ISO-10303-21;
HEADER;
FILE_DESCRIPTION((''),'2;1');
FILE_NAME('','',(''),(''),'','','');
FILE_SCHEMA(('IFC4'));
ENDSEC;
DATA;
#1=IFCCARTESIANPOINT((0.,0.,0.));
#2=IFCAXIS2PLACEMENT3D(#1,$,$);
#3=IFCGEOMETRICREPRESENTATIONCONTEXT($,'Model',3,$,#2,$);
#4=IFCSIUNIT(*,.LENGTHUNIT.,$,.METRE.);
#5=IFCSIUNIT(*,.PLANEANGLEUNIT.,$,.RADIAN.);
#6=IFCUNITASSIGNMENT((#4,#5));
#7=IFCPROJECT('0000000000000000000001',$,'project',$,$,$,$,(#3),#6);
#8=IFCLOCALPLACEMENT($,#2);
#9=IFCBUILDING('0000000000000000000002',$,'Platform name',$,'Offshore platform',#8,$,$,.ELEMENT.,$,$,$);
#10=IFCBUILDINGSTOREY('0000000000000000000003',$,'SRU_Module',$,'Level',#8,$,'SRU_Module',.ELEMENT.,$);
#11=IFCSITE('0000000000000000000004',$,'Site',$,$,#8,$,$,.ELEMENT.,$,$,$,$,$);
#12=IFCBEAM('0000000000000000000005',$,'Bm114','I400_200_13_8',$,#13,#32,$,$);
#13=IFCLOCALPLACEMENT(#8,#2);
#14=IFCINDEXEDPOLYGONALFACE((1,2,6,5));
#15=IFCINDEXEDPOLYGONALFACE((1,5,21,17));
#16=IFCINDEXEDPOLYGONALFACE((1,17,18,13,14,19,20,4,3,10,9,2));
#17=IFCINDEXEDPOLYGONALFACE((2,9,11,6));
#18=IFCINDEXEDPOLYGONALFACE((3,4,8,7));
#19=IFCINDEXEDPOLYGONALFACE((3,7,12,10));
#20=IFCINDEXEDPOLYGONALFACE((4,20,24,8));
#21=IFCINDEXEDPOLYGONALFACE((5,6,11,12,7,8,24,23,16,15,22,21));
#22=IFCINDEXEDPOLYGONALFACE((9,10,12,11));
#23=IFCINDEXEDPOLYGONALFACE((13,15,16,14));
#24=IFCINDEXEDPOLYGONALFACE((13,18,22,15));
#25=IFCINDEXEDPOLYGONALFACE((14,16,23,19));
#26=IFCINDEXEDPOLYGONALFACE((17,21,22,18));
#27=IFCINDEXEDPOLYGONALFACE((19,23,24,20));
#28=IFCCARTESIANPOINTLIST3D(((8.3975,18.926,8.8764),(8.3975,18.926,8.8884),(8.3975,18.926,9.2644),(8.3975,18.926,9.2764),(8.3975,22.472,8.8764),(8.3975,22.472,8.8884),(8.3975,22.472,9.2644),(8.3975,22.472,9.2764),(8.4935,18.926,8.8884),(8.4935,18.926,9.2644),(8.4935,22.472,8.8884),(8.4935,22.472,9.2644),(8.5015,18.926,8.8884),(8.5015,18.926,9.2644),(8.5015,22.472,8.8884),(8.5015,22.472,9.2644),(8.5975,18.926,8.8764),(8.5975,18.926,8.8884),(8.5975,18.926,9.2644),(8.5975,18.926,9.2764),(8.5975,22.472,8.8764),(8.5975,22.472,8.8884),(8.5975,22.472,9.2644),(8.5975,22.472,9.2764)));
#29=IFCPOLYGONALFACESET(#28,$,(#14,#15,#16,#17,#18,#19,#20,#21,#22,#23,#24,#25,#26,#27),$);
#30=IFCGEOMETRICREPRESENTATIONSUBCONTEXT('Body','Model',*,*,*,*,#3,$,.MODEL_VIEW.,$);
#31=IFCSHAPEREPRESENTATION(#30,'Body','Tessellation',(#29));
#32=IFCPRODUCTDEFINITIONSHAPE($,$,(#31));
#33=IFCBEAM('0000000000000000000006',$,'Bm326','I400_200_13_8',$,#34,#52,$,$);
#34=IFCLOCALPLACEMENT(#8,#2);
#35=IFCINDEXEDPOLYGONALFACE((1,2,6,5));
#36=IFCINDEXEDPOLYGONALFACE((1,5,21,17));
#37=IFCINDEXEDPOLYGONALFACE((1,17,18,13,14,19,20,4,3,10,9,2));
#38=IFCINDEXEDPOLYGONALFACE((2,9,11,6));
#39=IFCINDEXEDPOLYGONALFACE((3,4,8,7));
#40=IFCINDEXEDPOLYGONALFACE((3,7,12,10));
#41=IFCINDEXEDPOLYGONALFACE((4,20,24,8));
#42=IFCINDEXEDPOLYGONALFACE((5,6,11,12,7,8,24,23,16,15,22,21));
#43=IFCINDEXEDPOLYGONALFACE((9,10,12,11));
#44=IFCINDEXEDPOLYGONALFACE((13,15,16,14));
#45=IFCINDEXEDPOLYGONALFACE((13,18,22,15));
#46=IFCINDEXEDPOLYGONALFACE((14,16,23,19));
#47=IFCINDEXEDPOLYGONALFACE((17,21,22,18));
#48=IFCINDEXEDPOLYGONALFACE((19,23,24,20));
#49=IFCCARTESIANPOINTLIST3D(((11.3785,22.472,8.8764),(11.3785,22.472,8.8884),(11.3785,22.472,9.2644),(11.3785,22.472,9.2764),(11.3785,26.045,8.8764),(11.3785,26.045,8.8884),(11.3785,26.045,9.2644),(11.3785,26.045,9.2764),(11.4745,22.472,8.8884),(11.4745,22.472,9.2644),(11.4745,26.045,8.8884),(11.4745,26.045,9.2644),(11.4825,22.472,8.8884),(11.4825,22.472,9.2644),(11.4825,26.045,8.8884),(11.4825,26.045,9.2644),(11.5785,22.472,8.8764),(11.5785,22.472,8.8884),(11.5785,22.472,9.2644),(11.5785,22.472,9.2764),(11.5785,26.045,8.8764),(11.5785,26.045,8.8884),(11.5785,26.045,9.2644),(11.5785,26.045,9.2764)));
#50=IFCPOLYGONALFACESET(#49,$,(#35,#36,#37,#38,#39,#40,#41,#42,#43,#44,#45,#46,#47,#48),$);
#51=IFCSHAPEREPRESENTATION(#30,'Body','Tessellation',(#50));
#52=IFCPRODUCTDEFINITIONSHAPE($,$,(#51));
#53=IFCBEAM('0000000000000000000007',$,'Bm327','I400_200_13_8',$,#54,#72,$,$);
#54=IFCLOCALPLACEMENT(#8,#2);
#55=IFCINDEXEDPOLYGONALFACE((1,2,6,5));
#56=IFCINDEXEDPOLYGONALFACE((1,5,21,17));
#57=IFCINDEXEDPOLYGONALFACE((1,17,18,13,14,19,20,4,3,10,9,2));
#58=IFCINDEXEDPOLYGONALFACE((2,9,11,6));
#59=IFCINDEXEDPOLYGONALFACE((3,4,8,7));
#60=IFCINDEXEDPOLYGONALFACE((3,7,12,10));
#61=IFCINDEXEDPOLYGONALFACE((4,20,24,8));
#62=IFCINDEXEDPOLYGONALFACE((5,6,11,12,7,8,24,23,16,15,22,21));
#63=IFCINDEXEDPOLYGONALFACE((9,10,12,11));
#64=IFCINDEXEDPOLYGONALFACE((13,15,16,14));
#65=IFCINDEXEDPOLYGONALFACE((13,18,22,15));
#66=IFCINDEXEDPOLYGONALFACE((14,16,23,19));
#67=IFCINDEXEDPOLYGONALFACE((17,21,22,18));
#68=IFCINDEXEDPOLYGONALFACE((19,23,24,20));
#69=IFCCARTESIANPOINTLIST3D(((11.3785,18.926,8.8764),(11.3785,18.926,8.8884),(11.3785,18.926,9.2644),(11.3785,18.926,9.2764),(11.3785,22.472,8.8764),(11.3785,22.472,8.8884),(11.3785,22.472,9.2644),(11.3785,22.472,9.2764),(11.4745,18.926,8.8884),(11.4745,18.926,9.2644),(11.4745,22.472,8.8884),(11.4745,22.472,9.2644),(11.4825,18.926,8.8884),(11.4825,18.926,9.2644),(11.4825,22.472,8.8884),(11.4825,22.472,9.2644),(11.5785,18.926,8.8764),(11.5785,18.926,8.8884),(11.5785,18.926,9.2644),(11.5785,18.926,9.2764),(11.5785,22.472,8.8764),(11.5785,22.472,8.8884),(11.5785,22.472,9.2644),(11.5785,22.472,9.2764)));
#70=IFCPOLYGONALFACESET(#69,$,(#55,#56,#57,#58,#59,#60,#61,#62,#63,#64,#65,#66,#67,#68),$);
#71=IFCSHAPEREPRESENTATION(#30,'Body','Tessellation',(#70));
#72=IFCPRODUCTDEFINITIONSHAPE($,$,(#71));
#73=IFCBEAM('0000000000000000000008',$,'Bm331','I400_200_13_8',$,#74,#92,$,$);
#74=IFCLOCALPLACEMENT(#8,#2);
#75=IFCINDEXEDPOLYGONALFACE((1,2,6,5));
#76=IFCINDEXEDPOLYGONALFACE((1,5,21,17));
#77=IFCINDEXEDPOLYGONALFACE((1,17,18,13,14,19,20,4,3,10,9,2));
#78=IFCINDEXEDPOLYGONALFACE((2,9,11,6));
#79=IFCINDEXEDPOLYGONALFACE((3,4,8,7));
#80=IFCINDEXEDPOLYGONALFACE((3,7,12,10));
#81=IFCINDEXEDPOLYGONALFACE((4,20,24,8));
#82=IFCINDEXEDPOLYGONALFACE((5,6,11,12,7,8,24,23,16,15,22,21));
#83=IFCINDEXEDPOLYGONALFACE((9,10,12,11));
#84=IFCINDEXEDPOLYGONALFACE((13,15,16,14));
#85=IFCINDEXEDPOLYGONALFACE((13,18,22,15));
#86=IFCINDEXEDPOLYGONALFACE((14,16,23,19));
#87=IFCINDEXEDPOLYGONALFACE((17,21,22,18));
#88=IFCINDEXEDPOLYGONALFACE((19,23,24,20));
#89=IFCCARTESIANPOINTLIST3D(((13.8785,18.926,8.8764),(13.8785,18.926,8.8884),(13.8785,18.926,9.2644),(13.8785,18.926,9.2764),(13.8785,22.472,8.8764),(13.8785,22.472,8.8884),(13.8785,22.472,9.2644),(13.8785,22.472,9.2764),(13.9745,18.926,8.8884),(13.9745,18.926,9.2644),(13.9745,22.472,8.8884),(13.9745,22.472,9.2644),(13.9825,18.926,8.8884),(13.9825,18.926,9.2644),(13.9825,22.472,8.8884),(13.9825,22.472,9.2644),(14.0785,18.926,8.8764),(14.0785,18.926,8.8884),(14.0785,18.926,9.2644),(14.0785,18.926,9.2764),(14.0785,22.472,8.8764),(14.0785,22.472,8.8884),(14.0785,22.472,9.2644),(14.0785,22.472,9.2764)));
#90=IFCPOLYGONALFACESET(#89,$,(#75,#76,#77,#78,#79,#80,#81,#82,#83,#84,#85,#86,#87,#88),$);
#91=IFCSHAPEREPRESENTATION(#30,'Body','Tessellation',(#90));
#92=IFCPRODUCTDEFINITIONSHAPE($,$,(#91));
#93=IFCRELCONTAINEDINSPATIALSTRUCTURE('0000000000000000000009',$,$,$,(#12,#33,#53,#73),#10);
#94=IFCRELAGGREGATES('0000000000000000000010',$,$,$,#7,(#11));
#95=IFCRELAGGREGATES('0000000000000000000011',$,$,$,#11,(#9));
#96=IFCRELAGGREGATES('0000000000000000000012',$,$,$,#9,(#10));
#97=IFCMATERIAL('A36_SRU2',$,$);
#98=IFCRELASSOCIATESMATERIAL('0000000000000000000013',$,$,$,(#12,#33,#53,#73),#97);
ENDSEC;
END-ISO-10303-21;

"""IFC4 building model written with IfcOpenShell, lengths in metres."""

from ifc_helpers import new_model, si_unit, frame, origin, origin_2d, place, context, subcontext, project, spatial, i_section, extrude, source, transform, mapped, material, element, save


model = new_model("IFC4")

# Units and contexts
model_context = context("Model", 3, world=origin())
body_context = subcontext(model_context, "Body", "Model", "MODEL_VIEW")
ifc_project = project(units=[si_unit("LENGTHUNIT", "METRE"), si_unit("PLANEANGLEUNIT", "RADIAN")], contexts=[model_context])

# Site, building, storey
placement_1 = place(None, origin())
site = spatial("IfcSite", under=ifc_project, at=placement_1, Name="Site", CompositionType="ELEMENT")
building = spatial("IfcBuilding", under=site, at=placement_1, Name="Platform name", ObjectType="Offshore platform", CompositionType="ELEMENT")
storey = spatial("IfcBuildingStorey", under=building, at=placement_1, Name="SRU_Module", ObjectType="Level", LongName="SRU_Module", CompositionType="ELEMENT")

# Beams
ifc_material_1 = material(Name="A36_SRU2")
shared_shape_1 = source(origin(), body_context, "Body", "SweptSolid", [
    extrude(i_section(OverallWidth=0.2, OverallDepth=0.4, WebThickness=0.008, FlangeThickness=0.012, FilletRadius=0.0, at=origin_2d()), frame((0.0, 0.0, 0.0), z_axis=(0.0, 1.0, 0.0), x_axis=(-1.0, 0.0, 0.0)), (0.0, 0.0, 1.0), 3.546),
])
placement_2 = place(None, origin())
placement_3 = place(placement_2, origin())
placement_4 = place(placement_3, origin())
beam_1_placement = place(placement_4, frame((8.4975, 18.926, 9.0764)))
element("IfcBeam", 1, at=beam_1_placement, inside=storey, material=ifc_material_1, Name="Bm114", Description="I400_200_13_8", context=body_context, shape_type="MappedRepresentation", body=[
    mapped(shared_shape_1, transform((0.0, 0.0, 0.0), scale=1.0)),
])
shared_shape_2 = source(origin(), body_context, "Body", "SweptSolid", [
    extrude(i_section(OverallWidth=0.2, OverallDepth=0.4, WebThickness=0.008, FlangeThickness=0.012, FilletRadius=0.0, at=origin_2d()), frame((0.0, 0.0, 0.0), z_axis=(0.0, 1.0, 0.0), x_axis=(-1.0, 0.0, 0.0)), (0.0, 0.0, 1.0), 3.573),
])
placement_5 = place(None, origin())
placement_6 = place(placement_5, origin())
placement_7 = place(placement_6, origin())
beam_2_placement = place(placement_7, frame((11.4785, 22.472, 9.0764)))
element("IfcBeam", 2, at=beam_2_placement, inside=storey, material=ifc_material_1, Name="Bm326", Description="I400_200_13_8", context=body_context, shape_type="MappedRepresentation", body=[
    mapped(shared_shape_2, transform((0.0, 0.0, 0.0), scale=1.0)),
])
shared_shape_3 = source(origin(), body_context, "Body", "SweptSolid", [
    extrude(i_section(OverallWidth=0.2, OverallDepth=0.4, WebThickness=0.008, FlangeThickness=0.012, FilletRadius=0.0, at=origin_2d()), frame((0.0, 0.0, 0.0), z_axis=(0.0, 1.0, 0.0), x_axis=(-1.0, 0.0, 0.0)), (0.0, 0.0, 1.0), 3.546),
])
placement_8 = place(None, origin())
placement_9 = place(placement_8, origin())
placement_10 = place(placement_9, origin())
beam_3_placement = place(placement_10, frame((11.4785, 18.926, 9.0764)))
element("IfcBeam", 3, at=beam_3_placement, inside=storey, material=ifc_material_1, Name="Bm327", Description="I400_200_13_8", context=body_context, shape_type="MappedRepresentation", body=[
    mapped(shared_shape_3, transform((0.0, 0.0, 0.0), scale=1.0)),
])
shared_shape_4 = source(origin(), body_context, "Body", "SweptSolid", [
    extrude(i_section(OverallWidth=0.2, OverallDepth=0.4, WebThickness=0.008, FlangeThickness=0.012, FilletRadius=0.0, at=origin_2d()), frame((0.0, 0.0, 0.0), z_axis=(0.0, 1.0, 0.0), x_axis=(-1.0, 0.0, 0.0)), (0.0, 0.0, 1.0), 3.546),
])
placement_11 = place(None, origin())
placement_12 = place(placement_11, origin())
placement_13 = place(placement_12, origin())
beam_4_placement = place(placement_13, frame((13.9785, 18.926, 9.0764)))
element("IfcBeam", 4, at=beam_4_placement, inside=storey, material=ifc_material_1, Name="Bm331", Description="I400_200_13_8", context=body_context, shape_type="MappedRepresentation", body=[
    mapped(shared_shape_4, transform((0.0, 0.0, 0.0), scale=1.0)),
])

save(model, "model.ifc")
